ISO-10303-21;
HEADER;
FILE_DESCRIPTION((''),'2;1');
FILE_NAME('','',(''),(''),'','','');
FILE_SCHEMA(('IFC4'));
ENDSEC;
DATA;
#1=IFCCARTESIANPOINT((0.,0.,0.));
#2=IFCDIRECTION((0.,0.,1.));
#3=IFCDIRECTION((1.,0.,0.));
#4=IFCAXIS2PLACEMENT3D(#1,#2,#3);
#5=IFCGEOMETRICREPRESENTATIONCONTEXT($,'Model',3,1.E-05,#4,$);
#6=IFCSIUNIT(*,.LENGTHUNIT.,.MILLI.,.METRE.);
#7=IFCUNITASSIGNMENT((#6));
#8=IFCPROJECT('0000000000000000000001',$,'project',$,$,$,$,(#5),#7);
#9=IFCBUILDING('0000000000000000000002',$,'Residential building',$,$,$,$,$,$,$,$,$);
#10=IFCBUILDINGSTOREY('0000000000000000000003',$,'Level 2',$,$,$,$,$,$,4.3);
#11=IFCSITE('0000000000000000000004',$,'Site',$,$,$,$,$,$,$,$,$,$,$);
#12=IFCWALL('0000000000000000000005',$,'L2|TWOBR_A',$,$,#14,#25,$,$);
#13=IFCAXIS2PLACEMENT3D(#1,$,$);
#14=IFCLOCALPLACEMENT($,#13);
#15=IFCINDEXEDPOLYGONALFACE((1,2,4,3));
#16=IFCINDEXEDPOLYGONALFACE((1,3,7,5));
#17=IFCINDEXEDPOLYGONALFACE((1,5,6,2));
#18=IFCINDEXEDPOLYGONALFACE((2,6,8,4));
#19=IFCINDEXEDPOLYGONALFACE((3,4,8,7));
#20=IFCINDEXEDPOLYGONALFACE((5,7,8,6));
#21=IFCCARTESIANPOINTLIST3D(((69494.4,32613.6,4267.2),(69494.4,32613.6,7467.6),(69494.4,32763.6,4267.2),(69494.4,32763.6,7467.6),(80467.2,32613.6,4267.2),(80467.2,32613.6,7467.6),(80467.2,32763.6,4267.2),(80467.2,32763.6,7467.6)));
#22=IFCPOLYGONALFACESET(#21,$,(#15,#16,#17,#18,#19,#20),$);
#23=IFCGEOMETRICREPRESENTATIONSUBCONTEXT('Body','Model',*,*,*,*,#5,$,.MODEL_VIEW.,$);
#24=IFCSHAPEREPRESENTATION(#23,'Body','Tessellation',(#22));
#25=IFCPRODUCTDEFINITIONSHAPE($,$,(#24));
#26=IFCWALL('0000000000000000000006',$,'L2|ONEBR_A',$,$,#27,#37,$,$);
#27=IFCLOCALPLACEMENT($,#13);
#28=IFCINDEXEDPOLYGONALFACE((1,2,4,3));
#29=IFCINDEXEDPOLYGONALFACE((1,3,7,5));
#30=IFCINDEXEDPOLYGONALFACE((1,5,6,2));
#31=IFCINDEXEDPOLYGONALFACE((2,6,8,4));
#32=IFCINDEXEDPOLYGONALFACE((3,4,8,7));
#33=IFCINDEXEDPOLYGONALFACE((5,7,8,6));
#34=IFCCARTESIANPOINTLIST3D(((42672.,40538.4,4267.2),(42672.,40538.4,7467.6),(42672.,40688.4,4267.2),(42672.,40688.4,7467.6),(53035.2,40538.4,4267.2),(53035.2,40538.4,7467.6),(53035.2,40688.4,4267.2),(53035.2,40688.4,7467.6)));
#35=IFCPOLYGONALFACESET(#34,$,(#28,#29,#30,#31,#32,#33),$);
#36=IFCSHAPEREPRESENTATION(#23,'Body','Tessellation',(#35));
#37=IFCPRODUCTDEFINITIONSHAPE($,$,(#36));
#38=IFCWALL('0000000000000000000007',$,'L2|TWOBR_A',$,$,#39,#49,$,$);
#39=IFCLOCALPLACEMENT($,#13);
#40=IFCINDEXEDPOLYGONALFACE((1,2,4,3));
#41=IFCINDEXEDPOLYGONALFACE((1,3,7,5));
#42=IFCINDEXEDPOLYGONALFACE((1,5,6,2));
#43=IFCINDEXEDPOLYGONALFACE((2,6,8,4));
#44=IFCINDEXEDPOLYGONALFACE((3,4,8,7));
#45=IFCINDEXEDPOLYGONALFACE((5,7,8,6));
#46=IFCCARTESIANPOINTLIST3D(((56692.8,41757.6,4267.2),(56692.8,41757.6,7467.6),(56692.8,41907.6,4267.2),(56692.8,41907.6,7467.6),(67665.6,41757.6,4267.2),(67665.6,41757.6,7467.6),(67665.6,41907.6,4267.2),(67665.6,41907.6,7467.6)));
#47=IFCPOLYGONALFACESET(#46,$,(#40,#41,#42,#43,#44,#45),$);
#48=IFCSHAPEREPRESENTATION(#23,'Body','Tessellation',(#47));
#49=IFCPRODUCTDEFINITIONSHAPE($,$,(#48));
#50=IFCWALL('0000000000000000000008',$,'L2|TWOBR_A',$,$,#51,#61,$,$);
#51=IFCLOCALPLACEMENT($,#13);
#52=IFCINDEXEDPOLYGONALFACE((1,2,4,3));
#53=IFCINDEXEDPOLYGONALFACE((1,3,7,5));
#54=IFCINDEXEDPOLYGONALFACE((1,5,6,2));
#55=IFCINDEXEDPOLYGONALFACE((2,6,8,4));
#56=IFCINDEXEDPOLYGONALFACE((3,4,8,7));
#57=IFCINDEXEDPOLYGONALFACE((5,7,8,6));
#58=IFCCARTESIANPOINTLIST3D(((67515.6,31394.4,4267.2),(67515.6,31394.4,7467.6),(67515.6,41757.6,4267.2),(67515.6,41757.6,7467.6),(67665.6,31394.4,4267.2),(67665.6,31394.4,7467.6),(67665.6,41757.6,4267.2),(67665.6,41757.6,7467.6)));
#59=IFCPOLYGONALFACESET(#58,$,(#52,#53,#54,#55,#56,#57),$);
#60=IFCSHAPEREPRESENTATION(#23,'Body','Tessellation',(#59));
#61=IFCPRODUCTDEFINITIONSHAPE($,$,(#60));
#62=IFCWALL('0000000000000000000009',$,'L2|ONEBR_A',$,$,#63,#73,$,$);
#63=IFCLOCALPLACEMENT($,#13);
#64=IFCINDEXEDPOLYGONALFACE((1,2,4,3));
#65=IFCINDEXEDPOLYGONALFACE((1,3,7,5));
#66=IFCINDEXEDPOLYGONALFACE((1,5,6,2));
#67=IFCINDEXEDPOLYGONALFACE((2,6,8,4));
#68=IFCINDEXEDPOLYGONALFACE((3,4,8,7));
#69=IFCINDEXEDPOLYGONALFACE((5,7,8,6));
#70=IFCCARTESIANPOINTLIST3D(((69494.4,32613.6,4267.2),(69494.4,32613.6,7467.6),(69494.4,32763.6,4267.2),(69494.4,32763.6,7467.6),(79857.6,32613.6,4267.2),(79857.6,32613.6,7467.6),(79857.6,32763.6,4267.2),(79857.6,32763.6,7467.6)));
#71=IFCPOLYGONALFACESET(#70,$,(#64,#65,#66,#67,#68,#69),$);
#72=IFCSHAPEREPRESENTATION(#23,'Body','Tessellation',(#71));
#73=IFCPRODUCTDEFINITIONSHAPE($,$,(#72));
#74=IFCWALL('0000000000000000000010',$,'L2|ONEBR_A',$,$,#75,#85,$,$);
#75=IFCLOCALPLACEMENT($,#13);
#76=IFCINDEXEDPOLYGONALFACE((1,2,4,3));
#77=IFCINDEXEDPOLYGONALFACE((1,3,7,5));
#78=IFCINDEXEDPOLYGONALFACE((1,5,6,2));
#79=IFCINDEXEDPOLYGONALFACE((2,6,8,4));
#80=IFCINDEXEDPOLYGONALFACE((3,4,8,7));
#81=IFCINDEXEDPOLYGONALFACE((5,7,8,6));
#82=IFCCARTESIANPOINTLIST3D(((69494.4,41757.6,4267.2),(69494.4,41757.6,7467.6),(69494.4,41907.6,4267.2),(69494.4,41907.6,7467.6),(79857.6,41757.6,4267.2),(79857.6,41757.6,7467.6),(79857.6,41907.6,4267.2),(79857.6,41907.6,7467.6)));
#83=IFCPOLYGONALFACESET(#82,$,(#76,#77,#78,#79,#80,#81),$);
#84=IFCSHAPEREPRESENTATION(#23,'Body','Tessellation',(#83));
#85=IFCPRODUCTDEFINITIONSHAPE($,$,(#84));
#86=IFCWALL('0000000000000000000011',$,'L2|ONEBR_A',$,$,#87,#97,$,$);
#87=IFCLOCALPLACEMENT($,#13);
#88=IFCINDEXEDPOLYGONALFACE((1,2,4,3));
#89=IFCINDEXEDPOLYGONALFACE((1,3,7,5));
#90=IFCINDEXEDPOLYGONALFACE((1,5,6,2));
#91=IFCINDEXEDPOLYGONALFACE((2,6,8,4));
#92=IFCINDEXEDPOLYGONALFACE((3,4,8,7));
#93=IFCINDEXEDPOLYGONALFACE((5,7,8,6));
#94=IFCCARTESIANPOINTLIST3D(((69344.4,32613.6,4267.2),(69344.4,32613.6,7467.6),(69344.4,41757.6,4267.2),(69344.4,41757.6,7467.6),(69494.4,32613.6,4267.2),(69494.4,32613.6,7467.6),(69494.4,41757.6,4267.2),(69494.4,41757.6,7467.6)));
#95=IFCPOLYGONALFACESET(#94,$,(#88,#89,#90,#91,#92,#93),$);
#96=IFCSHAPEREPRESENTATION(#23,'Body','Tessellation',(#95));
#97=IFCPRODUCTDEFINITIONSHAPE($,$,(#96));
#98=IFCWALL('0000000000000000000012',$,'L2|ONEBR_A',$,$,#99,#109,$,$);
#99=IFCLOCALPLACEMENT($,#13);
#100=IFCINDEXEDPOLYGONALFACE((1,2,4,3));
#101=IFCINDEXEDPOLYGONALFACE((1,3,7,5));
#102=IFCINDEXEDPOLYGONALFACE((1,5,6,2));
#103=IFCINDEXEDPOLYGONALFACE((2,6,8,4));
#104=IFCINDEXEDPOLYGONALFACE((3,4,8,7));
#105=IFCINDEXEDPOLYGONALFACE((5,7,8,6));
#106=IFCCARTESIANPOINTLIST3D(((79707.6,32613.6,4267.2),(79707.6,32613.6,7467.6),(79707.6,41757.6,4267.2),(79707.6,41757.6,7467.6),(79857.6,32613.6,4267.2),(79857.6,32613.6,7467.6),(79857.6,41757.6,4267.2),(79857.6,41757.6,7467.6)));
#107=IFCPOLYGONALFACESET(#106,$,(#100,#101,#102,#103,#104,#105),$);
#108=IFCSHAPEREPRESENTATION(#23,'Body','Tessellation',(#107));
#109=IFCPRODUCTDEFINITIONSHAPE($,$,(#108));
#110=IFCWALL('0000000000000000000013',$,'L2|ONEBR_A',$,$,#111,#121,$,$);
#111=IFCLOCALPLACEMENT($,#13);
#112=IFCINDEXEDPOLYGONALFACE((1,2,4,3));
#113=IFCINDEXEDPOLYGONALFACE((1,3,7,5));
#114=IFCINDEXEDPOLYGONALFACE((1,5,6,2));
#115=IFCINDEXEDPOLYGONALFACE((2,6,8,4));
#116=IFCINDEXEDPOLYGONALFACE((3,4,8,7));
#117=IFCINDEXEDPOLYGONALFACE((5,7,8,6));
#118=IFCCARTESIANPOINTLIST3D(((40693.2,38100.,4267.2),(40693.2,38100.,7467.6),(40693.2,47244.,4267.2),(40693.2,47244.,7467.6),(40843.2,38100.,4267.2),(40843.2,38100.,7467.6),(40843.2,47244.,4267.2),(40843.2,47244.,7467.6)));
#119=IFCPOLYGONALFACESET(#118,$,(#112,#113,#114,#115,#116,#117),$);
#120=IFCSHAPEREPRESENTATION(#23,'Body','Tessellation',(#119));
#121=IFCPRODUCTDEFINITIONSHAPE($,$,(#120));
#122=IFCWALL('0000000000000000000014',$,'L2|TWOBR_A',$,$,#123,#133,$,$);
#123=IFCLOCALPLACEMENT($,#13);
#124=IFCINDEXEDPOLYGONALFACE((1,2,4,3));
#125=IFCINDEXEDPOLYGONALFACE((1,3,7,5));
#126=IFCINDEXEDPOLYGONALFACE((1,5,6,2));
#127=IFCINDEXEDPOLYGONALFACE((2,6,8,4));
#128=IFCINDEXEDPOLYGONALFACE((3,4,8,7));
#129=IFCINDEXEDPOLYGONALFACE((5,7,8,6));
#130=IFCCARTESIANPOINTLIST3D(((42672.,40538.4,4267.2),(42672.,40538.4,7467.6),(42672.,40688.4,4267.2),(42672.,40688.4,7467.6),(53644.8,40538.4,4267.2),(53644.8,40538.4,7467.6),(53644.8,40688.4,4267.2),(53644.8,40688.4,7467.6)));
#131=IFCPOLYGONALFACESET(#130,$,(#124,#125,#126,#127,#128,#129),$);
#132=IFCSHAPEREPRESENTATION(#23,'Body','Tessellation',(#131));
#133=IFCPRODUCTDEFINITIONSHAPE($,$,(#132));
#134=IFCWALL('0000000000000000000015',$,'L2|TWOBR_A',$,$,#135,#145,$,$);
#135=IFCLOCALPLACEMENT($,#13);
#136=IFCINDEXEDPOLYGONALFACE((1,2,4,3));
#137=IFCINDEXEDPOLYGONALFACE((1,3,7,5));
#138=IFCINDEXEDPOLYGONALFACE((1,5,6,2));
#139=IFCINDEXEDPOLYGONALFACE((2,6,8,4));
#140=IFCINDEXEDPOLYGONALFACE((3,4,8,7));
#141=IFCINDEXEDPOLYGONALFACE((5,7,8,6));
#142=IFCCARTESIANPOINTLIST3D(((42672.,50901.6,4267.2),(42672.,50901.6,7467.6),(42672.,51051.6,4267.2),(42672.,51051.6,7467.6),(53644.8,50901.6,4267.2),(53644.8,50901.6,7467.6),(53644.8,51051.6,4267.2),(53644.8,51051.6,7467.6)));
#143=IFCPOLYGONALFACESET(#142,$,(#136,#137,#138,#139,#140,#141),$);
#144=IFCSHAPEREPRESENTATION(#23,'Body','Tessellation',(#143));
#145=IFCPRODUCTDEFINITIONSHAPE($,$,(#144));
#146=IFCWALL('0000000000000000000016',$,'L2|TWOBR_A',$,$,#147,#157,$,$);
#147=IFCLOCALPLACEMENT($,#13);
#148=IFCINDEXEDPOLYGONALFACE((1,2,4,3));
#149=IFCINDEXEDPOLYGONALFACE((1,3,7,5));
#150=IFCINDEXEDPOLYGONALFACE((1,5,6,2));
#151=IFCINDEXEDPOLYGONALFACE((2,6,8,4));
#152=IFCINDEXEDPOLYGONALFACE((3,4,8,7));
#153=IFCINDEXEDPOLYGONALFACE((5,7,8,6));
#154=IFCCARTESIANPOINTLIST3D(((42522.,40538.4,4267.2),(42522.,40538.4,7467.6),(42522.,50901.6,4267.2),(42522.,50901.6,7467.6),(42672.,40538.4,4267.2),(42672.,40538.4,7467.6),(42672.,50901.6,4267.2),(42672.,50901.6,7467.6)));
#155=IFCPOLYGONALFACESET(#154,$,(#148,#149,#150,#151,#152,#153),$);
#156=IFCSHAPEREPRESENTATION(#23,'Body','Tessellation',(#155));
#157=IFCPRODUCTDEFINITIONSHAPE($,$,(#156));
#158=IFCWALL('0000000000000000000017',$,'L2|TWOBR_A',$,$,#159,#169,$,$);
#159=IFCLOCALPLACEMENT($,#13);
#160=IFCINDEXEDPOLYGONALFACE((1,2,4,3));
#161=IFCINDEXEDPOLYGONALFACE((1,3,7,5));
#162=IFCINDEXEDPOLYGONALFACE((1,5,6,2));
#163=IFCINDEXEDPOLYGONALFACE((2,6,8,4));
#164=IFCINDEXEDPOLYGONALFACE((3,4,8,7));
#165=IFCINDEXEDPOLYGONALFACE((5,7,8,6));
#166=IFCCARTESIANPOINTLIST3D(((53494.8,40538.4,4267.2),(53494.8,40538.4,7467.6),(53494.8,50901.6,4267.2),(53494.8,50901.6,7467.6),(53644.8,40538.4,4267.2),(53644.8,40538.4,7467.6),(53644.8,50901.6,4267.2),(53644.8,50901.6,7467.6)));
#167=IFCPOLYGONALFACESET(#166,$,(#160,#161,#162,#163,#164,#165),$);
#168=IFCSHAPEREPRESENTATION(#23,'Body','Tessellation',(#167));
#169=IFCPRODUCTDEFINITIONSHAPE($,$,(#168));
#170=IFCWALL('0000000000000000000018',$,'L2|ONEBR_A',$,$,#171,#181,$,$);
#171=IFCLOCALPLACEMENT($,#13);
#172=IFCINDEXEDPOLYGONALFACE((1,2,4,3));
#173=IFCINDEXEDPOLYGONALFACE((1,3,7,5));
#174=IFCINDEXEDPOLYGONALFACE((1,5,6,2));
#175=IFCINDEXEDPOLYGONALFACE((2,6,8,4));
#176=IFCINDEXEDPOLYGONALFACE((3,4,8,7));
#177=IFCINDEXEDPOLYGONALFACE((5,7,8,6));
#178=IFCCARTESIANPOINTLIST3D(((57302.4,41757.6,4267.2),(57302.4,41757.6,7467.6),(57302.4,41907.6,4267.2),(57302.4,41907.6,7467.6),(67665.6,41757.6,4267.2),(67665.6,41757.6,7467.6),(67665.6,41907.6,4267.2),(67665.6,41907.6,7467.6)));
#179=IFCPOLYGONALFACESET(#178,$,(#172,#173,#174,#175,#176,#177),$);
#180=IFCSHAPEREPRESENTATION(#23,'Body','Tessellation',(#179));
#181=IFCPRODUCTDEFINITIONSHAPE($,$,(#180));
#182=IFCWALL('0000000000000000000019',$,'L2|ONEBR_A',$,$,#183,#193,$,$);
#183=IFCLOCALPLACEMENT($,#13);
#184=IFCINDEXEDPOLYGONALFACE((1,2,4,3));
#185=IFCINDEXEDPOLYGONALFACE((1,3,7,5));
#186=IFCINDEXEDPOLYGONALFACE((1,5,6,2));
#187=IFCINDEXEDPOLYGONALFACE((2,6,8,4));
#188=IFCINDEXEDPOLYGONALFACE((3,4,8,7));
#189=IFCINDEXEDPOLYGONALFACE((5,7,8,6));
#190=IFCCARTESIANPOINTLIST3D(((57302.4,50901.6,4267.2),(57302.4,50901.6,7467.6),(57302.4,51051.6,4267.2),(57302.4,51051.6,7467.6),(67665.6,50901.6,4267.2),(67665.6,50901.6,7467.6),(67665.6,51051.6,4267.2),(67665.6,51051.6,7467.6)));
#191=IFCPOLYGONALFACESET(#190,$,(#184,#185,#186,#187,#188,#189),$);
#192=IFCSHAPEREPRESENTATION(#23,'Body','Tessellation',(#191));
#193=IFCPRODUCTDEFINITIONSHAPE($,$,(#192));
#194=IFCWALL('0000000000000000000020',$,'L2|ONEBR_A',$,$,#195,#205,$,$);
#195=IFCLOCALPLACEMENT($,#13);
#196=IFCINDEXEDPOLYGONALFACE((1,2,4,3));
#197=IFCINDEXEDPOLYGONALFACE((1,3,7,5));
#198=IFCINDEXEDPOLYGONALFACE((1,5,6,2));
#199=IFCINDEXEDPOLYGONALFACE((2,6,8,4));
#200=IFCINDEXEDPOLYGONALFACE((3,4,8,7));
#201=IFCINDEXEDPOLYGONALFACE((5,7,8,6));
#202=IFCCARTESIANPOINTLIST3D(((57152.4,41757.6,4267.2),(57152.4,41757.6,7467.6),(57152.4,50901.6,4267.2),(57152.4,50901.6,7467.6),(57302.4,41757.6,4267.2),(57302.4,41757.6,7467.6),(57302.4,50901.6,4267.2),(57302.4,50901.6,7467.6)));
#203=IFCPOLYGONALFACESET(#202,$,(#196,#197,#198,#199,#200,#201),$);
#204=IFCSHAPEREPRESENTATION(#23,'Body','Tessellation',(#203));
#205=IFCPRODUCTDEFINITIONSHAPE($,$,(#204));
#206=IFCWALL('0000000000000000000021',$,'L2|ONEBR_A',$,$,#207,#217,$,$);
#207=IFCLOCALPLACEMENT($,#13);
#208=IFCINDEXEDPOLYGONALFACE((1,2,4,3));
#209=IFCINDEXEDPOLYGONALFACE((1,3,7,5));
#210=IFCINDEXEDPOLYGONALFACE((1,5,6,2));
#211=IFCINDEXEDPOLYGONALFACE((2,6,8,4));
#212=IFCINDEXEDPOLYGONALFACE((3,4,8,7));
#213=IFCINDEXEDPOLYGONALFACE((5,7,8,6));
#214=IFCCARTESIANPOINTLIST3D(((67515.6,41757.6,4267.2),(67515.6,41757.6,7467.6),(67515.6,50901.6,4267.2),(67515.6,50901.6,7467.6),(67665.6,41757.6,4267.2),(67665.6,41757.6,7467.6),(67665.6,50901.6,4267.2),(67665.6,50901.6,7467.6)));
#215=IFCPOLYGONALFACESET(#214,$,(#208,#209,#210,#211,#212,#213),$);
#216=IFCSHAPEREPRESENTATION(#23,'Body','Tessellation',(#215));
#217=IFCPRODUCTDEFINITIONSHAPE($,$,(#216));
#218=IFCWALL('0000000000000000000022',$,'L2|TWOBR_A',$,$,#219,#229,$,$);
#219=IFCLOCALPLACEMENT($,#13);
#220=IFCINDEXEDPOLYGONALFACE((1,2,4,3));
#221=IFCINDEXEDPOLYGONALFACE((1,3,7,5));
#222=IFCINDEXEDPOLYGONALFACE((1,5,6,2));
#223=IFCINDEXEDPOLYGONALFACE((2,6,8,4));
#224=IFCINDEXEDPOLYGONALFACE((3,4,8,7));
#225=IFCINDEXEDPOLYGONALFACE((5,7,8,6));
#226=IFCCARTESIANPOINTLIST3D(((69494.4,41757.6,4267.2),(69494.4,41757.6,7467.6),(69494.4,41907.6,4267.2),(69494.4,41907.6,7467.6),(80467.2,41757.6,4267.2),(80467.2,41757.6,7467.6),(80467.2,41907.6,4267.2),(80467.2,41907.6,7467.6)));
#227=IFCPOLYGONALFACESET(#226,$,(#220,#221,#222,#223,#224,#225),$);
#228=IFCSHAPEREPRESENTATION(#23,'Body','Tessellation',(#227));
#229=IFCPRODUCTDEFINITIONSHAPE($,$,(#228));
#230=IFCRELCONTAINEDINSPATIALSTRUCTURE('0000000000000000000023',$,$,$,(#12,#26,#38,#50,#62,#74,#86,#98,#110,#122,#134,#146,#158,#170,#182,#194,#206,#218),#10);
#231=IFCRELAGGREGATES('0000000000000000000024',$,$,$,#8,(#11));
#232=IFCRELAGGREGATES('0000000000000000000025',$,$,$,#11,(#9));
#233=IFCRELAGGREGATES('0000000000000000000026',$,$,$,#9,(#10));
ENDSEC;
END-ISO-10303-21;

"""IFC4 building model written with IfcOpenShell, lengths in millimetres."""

from ifc_helpers import new_model, si_unit, frame, origin_with_axes, place, context, subcontext, project, spatial, indexed_curve, outline, extrude, element, save


model = new_model("IFC4")

# Units and contexts
model_context = context("Model", 3, precision=1e-05, world=origin_with_axes())
body_context = subcontext(model_context, "Body", "Model", "MODEL_VIEW")
ifc_project = project(units=[si_unit("LENGTHUNIT", "METRE", prefix="MILLI")], contexts=[model_context])

# Site, building, storey
site = spatial("IfcSite", under=ifc_project, Name="Site")
building = spatial("IfcBuilding", under=site, Name="Residential building")
storey = spatial("IfcBuildingStorey", under=building, Name="Level 2", Elevation=4.3)

# Walls
wall_1_placement = place(None, frame((69494.4, 32613.6, 4267.2), z_axis=(0.0, 0.0, 1.0), x_axis=(1.0, 0.0, 0.0)))
element("IfcWall", 1, at=wall_1_placement, inside=storey, Name="L2|TWOBR_A", context=body_context, shape_type="SweptSolid", body=[
    extrude(outline(indexed_curve([(0.0, 0.0), (0.0, 150.0), (10972.8, 150.0), (10972.8, 0.0), (0.0, 0.0)], self_intersect=False)), origin_with_axes(), (0.0, 0.0, 1.0), 3200.4),
])
wall_2_placement = place(None, frame((42672.0, 40538.4, 4267.2), z_axis=(0.0, 0.0, 1.0), x_axis=(1.0, 0.0, 0.0)))
element("IfcWall", 2, at=wall_2_placement, inside=storey, Name="L2|ONEBR_A", context=body_context, shape_type="SweptSolid", body=[
    extrude(outline(indexed_curve([(0.0, 0.0), (0.0, 150.0), (10363.2, 150.0), (10363.2, 0.0), (0.0, 0.0)], self_intersect=False)), origin_with_axes(), (0.0, 0.0, 1.0), 3200.4),
])
wall_3_placement = place(None, frame((56692.8, 41757.6, 4267.2), z_axis=(0.0, 0.0, 1.0), x_axis=(1.0, 0.0, 0.0)))
element("IfcWall", 3, at=wall_3_placement, inside=storey, Name="L2|TWOBR_A", context=body_context, shape_type="SweptSolid", body=[
    extrude(outline(indexed_curve([(0.0, 0.0), (0.0, 150.0), (10972.8, 150.0), (10972.8, 0.0), (0.0, 0.0)], self_intersect=False)), origin_with_axes(), (0.0, 0.0, 1.0), 3200.4),
])
for number, where, z_axis, x_axis, name in (
    (4, (67665.6, 31394.4, 4267.2), (0.0, 0.0, 1.0), (0.0, 1.0, 0.0), "L2|TWOBR_A"),
    (5, (69494.4, 32613.6, 4267.2), (0.0, 0.0, 1.0), (1.0, 0.0, 0.0), "L2|ONEBR_A"),
    (6, (69494.4, 41757.6, 4267.2), (0.0, 0.0, 1.0), (1.0, 0.0, 0.0), "L2|ONEBR_A"),
):
    element("IfcWall", number, at=place(None, frame(where, z_axis=z_axis, x_axis=x_axis)), inside=storey, Name=name, context=body_context, shape_type="SweptSolid", body=[
        extrude(outline(indexed_curve([(0.0, 0.0), (0.0, 150.0), (10363.2, 150.0), (10363.2, 0.0), (0.0, 0.0)], self_intersect=False)), origin_with_axes(), (0.0, 0.0, 1.0), 3200.4),
    ])
for number, where, z_axis, x_axis, name in (
    (7, (69494.4, 32613.6, 4267.2), (0.0, 0.0, 1.0), (0.0, 1.0, 0.0), "L2|ONEBR_A"),
    (8, (79857.6, 32613.6, 4267.2), (0.0, 0.0, 1.0), (0.0, 1.0, 0.0), "L2|ONEBR_A"),
    (9, (40843.2, 38100.0, 4267.2), (0.0, 0.0, 1.0), (0.0, 1.0, 0.0), "L2|ONEBR_A"),
):
    element("IfcWall", number, at=place(None, frame(where, z_axis=z_axis, x_axis=x_axis)), inside=storey, Name=name, context=body_context, shape_type="SweptSolid", body=[
        extrude(outline(indexed_curve([(0.0, 0.0), (0.0, 150.0), (9144.0, 150.0), (9144.0, 0.0), (0.0, 0.0)], self_intersect=False)), origin_with_axes(), (0.0, 0.0, 1.0), 3200.4),
    ])
for number, where, z_axis, x_axis, name in (
    (10, (42672.0, 40538.4, 4267.2), (0.0, 0.0, 1.0), (1.0, 0.0, 0.0), "L2|TWOBR_A"),
    (11, (42672.0, 50901.6, 4267.2), (0.0, 0.0, 1.0), (1.0, 0.0, 0.0), "L2|TWOBR_A"),
):
    element("IfcWall", number, at=place(None, frame(where, z_axis=z_axis, x_axis=x_axis)), inside=storey, Name=name, context=body_context, shape_type="SweptSolid", body=[
        extrude(outline(indexed_curve([(0.0, 0.0), (0.0, 150.0), (10972.8, 150.0), (10972.8, 0.0), (0.0, 0.0)], self_intersect=False)), origin_with_axes(), (0.0, 0.0, 1.0), 3200.4),
    ])
for number, where, z_axis, x_axis, name in (
    (12, (42672.0, 40538.4, 4267.2), (0.0, 0.0, 1.0), (0.0, 1.0, 0.0), "L2|TWOBR_A"),
    (13, (53644.8, 40538.4, 4267.2), (0.0, 0.0, 1.0), (0.0, 1.0, 0.0), "L2|TWOBR_A"),
    (14, (57302.4, 41757.6, 4267.2), (0.0, 0.0, 1.0), (1.0, 0.0, 0.0), "L2|ONEBR_A"),
    (15, (57302.4, 50901.6, 4267.2), (0.0, 0.0, 1.0), (1.0, 0.0, 0.0), "L2|ONEBR_A"),
):
    element("IfcWall", number, at=place(None, frame(where, z_axis=z_axis, x_axis=x_axis)), inside=storey, Name=name, context=body_context, shape_type="SweptSolid", body=[
        extrude(outline(indexed_curve([(0.0, 0.0), (0.0, 150.0), (10363.2, 150.0), (10363.2, 0.0), (0.0, 0.0)], self_intersect=False)), origin_with_axes(), (0.0, 0.0, 1.0), 3200.4),
    ])
for number, where, z_axis, x_axis, name in (
    (16, (57302.4, 41757.6, 4267.2), (0.0, 0.0, 1.0), (0.0, 1.0, 0.0), "L2|ONEBR_A"),
    (17, (67665.6, 41757.6, 4267.2), (0.0, 0.0, 1.0), (0.0, 1.0, 0.0), "L2|ONEBR_A"),
):
    element("IfcWall", number, at=place(None, frame(where, z_axis=z_axis, x_axis=x_axis)), inside=storey, Name=name, context=body_context, shape_type="SweptSolid", body=[
        extrude(outline(indexed_curve([(0.0, 0.0), (0.0, 150.0), (9144.0, 150.0), (9144.0, 0.0), (0.0, 0.0)], self_intersect=False)), origin_with_axes(), (0.0, 0.0, 1.0), 3200.4),
    ])
for number, where, z_axis, x_axis, name in (
    (18, (69494.4, 41757.6, 4267.2), (0.0, 0.0, 1.0), (1.0, 0.0, 0.0), "L2|TWOBR_A"),
):
    element("IfcWall", number, at=place(None, frame(where, z_axis=z_axis, x_axis=x_axis)), inside=storey, Name=name, context=body_context, shape_type="SweptSolid", body=[
        extrude(outline(indexed_curve([(0.0, 0.0), (0.0, 150.0), (10972.8, 150.0), (10972.8, 0.0), (0.0, 0.0)], self_intersect=False)), origin_with_axes(), (0.0, 0.0, 1.0), 3200.4),
    ])

save(model, "model.ifc")
